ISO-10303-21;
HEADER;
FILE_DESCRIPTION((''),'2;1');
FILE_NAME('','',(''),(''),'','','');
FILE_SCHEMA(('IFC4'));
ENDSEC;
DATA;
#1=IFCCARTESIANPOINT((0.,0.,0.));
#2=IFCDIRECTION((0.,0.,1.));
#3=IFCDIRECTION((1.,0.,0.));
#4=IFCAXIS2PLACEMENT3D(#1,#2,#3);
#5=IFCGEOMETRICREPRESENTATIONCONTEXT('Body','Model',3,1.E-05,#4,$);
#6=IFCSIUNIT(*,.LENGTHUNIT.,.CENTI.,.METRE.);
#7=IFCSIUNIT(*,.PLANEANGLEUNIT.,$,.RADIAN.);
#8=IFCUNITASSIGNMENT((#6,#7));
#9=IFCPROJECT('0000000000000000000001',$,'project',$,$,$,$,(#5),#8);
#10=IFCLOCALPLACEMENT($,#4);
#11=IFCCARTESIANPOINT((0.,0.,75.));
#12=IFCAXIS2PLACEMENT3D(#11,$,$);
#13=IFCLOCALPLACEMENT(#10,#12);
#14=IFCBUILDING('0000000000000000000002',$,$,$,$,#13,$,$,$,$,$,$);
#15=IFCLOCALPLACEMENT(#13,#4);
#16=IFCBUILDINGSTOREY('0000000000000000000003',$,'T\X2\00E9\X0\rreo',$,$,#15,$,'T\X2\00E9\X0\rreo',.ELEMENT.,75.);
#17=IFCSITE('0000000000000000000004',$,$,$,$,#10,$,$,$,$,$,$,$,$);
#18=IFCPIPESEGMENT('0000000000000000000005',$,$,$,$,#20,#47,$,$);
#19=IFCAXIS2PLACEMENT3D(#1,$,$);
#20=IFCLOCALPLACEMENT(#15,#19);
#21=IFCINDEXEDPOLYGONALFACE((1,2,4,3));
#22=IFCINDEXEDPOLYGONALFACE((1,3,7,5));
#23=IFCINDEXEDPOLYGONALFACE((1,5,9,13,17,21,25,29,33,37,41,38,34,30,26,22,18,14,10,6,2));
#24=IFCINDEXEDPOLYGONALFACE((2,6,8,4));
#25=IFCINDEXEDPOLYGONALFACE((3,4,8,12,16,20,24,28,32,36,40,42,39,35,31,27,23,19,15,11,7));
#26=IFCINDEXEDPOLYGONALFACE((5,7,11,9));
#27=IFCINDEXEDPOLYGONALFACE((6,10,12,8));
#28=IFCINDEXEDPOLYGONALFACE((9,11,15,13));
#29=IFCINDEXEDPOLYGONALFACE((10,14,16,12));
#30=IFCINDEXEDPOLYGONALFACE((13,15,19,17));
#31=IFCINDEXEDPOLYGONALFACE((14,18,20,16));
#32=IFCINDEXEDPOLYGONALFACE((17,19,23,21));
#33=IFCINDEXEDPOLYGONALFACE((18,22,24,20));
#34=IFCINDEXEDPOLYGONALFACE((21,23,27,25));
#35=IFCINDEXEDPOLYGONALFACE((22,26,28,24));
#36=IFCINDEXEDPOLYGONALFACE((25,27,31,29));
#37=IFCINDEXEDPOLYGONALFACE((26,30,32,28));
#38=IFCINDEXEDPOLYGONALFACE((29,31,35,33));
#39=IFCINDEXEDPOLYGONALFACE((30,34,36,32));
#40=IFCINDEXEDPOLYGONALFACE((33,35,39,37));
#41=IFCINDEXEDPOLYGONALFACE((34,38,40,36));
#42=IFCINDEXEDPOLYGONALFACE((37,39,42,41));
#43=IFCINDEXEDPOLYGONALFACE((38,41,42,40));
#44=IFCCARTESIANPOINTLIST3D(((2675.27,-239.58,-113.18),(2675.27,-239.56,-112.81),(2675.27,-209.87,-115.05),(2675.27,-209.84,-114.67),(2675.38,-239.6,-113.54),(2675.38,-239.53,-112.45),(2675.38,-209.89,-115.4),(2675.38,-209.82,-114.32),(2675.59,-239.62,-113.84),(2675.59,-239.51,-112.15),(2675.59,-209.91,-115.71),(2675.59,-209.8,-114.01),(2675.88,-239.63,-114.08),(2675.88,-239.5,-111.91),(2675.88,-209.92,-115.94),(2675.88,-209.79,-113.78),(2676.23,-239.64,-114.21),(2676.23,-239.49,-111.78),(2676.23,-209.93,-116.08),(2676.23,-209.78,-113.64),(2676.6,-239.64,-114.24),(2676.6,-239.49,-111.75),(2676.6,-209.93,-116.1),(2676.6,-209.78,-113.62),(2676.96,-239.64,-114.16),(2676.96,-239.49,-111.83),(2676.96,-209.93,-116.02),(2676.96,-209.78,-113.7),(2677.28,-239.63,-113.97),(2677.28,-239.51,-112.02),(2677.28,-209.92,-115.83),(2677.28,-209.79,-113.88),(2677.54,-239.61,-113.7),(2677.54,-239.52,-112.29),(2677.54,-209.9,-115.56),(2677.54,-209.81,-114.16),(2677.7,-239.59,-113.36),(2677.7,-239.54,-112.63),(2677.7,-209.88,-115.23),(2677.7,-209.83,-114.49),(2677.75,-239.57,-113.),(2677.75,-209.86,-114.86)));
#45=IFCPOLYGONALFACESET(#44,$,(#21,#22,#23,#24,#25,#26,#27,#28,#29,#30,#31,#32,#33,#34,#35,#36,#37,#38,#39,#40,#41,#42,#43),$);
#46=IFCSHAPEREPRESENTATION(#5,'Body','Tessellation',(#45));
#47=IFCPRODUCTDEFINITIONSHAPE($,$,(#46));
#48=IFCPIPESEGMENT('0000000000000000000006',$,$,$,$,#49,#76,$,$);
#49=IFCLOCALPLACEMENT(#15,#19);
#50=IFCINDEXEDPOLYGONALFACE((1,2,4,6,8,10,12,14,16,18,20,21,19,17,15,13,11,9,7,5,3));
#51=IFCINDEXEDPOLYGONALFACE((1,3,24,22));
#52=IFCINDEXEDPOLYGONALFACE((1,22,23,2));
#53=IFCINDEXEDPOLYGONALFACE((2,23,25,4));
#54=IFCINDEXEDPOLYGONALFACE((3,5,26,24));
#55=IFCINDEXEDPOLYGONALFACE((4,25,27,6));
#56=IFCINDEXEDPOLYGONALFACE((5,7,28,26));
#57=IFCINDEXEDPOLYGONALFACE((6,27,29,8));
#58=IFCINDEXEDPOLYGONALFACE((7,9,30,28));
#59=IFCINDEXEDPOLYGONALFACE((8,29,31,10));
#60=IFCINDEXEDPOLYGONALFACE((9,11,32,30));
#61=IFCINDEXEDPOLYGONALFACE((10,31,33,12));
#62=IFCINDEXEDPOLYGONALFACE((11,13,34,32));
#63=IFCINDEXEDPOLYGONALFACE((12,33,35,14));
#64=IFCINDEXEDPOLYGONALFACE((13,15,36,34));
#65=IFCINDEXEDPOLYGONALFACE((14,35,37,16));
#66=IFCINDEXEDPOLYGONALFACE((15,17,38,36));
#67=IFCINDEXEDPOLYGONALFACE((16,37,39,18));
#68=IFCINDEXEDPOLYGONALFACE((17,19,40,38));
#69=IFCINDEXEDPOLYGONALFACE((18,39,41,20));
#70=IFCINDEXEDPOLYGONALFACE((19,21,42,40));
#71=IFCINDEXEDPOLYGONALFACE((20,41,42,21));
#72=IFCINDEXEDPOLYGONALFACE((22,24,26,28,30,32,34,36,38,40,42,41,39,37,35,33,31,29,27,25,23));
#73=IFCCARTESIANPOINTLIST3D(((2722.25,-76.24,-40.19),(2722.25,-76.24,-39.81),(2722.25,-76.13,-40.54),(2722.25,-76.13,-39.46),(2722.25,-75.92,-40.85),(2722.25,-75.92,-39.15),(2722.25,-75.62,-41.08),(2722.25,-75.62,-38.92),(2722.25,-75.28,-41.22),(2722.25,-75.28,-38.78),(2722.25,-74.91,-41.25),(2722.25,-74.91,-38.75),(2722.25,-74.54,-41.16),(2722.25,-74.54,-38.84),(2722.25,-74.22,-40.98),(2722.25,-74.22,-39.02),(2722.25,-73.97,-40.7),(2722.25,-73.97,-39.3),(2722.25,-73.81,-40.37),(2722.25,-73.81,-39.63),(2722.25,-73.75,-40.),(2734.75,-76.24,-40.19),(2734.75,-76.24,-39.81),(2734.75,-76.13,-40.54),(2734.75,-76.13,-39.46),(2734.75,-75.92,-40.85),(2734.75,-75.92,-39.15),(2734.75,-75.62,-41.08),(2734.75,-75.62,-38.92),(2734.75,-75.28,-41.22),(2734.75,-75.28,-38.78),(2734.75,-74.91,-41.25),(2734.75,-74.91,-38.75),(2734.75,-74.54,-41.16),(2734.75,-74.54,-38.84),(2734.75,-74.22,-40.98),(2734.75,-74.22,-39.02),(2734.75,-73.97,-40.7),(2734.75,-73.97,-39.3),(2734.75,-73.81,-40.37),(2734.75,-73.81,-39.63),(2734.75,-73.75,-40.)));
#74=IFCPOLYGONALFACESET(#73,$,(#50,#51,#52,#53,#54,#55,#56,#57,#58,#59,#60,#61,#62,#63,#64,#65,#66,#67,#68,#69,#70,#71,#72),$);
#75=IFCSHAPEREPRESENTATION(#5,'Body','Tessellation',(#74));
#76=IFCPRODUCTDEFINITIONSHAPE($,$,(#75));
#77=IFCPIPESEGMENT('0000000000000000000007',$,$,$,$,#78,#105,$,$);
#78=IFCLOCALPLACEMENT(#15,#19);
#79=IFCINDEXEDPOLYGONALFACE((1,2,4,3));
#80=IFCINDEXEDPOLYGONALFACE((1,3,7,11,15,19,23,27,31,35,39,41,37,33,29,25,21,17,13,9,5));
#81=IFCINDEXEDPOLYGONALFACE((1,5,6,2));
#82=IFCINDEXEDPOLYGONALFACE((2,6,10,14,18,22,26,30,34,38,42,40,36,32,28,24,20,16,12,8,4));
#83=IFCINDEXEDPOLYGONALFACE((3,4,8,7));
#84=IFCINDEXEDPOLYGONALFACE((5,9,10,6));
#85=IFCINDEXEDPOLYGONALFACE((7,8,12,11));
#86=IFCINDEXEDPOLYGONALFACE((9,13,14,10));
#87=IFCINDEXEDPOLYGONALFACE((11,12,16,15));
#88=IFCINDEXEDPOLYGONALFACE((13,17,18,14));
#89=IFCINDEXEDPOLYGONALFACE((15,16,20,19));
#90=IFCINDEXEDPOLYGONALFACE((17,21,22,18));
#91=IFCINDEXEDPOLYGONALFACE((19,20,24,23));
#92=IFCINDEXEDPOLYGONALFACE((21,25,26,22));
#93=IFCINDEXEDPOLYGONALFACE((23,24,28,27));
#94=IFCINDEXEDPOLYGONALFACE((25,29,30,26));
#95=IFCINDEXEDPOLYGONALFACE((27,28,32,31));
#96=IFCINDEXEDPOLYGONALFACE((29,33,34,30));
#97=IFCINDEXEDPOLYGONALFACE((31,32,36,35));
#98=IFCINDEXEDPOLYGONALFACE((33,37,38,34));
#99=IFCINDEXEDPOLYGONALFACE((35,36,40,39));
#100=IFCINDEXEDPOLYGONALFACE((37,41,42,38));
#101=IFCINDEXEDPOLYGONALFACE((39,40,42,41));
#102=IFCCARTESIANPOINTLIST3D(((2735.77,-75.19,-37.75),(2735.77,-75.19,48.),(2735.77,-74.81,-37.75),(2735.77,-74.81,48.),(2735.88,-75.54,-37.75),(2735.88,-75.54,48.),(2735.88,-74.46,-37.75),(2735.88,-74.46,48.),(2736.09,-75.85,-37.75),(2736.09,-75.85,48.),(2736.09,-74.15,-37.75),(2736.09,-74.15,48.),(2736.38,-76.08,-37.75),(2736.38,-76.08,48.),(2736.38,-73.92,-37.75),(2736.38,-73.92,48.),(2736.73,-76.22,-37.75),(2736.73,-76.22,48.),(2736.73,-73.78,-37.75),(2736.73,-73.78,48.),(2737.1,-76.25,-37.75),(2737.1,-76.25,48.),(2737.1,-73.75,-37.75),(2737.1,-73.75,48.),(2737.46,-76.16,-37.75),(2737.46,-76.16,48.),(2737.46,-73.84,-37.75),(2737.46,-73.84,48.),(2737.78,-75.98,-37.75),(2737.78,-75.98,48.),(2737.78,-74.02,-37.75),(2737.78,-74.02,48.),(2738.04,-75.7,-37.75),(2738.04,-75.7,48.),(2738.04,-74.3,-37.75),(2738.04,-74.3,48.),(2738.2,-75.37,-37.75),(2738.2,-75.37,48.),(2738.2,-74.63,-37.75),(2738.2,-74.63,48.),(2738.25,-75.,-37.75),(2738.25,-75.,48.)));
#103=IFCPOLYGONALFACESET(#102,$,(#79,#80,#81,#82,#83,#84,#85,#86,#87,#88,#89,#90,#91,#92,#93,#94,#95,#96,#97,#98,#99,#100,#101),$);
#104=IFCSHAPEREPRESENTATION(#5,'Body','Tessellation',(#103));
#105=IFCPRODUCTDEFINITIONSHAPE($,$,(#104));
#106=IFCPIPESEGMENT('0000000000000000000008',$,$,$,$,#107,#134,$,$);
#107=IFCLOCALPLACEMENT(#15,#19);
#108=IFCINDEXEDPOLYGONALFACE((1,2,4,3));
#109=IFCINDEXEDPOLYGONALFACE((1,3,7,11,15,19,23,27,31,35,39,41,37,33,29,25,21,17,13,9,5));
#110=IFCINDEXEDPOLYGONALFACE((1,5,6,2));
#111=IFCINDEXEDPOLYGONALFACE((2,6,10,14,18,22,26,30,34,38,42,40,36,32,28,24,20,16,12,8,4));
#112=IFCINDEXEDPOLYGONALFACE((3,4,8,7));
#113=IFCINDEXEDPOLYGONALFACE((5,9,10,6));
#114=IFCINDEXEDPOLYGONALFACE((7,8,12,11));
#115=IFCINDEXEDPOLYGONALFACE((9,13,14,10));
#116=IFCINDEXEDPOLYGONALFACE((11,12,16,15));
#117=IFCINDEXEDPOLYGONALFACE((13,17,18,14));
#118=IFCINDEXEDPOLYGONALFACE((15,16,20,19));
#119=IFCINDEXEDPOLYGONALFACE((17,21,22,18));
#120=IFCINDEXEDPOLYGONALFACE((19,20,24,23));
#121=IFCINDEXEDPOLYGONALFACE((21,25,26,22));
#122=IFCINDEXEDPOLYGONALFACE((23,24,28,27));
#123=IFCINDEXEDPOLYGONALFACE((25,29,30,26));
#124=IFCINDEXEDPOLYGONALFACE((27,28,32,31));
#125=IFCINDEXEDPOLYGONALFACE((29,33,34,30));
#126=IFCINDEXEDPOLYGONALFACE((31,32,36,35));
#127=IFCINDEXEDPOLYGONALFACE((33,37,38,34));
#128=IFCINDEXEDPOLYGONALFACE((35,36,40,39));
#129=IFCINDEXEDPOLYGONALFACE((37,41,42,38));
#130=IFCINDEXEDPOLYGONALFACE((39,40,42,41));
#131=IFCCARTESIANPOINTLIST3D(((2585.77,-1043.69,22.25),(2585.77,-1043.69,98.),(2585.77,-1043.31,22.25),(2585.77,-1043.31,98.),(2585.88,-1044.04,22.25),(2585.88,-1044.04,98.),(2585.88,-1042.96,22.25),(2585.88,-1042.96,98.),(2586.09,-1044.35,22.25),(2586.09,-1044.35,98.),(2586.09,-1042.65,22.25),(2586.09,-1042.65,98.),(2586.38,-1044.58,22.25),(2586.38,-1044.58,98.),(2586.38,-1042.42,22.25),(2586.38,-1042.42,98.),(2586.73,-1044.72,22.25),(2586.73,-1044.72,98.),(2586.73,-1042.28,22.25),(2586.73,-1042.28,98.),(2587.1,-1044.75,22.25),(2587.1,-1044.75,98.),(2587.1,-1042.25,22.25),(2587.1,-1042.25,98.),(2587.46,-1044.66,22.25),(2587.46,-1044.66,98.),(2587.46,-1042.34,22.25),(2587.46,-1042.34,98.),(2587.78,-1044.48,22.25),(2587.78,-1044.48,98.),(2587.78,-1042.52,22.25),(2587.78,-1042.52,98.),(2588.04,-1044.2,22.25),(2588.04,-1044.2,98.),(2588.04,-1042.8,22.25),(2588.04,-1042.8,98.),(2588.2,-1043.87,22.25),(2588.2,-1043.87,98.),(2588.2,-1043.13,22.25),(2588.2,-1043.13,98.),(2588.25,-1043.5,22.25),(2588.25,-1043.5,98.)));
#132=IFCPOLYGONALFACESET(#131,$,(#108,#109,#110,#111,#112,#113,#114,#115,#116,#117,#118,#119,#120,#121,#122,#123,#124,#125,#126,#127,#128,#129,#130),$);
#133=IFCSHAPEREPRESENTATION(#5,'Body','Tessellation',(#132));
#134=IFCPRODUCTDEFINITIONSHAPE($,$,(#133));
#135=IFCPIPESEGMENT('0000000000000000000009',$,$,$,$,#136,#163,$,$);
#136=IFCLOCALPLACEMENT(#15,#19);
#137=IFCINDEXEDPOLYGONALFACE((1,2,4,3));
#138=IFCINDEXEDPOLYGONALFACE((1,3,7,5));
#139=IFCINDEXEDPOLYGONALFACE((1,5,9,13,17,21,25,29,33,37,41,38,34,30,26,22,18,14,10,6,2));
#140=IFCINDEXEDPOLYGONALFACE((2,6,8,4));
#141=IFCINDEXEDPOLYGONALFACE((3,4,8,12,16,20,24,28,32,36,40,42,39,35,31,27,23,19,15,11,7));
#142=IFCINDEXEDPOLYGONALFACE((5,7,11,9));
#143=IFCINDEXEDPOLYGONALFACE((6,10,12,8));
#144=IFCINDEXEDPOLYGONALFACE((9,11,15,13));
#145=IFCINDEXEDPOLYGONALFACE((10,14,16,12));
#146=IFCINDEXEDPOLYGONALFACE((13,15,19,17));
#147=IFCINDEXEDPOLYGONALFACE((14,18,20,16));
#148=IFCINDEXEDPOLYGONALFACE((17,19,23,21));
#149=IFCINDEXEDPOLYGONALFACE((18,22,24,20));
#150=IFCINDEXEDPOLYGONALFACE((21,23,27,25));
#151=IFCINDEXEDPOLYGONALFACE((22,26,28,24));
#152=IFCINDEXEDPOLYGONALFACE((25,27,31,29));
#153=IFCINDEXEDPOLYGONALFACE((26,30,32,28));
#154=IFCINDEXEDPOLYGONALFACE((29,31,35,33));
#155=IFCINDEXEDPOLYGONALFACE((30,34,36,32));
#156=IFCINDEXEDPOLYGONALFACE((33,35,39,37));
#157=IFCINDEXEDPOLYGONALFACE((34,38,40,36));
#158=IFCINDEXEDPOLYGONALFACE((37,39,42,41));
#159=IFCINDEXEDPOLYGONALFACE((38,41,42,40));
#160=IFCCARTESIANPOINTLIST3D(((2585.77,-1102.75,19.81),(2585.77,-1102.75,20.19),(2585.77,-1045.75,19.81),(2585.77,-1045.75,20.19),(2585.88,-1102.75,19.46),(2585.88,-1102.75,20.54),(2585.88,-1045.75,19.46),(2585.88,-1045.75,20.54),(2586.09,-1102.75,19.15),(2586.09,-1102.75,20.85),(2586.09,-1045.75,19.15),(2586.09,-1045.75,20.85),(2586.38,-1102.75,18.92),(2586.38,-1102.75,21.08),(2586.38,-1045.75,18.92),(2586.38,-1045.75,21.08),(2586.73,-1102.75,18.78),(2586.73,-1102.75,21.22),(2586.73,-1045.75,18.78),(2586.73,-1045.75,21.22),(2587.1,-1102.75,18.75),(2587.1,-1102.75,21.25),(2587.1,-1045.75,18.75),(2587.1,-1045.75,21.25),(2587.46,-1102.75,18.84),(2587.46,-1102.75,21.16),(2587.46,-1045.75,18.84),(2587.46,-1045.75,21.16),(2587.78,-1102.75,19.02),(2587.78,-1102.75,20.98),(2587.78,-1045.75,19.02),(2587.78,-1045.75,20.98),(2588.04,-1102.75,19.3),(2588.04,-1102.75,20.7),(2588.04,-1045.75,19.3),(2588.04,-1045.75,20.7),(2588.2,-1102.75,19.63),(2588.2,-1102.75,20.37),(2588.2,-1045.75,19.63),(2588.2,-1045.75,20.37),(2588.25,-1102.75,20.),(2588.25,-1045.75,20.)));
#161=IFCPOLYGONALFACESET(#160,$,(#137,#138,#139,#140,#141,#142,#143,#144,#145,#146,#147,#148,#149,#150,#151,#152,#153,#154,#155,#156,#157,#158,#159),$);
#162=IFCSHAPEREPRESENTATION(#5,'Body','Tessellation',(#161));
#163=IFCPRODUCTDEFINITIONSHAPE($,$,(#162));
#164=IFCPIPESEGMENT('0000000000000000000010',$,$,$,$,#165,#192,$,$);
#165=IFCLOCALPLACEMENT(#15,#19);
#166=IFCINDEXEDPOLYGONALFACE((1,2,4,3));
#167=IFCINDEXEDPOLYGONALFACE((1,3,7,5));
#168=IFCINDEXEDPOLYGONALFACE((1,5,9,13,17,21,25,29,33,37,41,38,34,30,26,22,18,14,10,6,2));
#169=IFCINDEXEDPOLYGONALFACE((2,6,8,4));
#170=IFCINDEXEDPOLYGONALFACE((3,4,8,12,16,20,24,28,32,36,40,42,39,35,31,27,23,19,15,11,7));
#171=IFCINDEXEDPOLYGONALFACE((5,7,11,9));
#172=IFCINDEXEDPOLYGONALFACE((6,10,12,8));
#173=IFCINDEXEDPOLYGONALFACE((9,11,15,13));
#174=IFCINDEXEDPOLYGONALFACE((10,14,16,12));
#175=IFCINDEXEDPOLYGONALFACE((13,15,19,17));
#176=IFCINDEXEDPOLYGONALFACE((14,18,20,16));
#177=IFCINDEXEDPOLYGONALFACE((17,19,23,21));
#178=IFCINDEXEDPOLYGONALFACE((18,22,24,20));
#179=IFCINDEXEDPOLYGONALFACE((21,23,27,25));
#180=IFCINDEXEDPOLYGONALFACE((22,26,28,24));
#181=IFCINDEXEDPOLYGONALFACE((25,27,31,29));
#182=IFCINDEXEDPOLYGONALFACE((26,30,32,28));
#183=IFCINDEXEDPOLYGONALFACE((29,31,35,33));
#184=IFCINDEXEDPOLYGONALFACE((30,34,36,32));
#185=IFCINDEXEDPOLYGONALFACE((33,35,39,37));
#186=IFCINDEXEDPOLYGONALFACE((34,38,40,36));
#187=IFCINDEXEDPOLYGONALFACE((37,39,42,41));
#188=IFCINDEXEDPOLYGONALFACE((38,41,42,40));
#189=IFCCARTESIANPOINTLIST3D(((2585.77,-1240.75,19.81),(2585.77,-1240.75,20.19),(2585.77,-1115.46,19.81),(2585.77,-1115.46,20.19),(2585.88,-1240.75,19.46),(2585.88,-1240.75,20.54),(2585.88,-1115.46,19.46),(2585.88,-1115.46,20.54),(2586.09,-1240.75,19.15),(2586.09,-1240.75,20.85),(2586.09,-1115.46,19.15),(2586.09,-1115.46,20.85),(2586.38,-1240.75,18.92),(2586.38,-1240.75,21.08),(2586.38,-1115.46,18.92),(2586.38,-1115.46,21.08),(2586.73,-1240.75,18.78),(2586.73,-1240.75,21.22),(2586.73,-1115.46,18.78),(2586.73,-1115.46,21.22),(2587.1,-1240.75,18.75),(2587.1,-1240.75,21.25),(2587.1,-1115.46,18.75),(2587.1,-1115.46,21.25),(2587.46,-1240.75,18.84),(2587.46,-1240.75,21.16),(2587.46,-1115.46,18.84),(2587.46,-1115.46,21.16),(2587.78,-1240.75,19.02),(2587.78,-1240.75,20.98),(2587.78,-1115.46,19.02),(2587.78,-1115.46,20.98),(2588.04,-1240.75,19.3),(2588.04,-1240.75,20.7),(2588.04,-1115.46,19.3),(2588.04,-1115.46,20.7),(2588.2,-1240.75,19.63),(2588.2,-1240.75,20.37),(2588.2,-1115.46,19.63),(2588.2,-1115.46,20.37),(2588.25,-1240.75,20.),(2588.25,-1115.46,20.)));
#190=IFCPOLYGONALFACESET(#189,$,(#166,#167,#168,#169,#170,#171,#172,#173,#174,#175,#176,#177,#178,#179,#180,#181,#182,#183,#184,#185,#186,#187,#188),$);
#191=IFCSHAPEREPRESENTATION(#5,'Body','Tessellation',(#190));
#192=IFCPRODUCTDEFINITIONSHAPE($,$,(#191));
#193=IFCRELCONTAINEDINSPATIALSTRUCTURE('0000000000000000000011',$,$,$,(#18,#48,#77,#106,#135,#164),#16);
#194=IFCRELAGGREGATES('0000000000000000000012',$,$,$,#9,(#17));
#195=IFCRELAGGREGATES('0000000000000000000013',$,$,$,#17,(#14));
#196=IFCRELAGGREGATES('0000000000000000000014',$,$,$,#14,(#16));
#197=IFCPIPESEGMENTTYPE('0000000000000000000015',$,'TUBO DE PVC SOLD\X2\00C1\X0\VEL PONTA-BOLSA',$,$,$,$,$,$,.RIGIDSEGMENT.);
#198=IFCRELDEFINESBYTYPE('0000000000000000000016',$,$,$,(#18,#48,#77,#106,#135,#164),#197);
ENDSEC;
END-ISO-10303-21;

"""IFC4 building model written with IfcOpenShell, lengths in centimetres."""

from ifc_helpers import new_model, si_unit, frame, origin_with_axes, origin_2d_with_axis, place, context, project, spatial, circle, extrude, type_object, element, save


model = new_model("IFC4")

# Units and contexts
model_context = context("Model", 3, precision=1e-05, world=origin_with_axes(), identifier="Body")
ifc_project = project(units=[si_unit("LENGTHUNIT", "METRE", prefix="CENTI"), si_unit("PLANEANGLEUNIT", "RADIAN")], contexts=[model_context])

# Site, building, storey
site_placement = place(None, origin_with_axes())
site = spatial("IfcSite", under=ifc_project, at=site_placement)
building_placement = place(site_placement, frame((0.0, 0.0, 75.0)))
building = spatial("IfcBuilding", under=site, at=building_placement)
storey_placement = place(building_placement, origin_with_axes())
storey = spatial("IfcBuildingStorey", under=building, at=storey_placement, Name="Térreo", LongName="Térreo", CompositionType="ELEMENT", Elevation=75.0)

# Pipe segments
pipe_segment_type_1 = type_object("IfcPipeSegmentType", Name="TUBO DE PVC SOLDÁVEL PONTA-BOLSA", PredefinedType="RIGIDSEGMENT")
pipe_segment_1_placement = place(storey_placement, frame((2676.5, -224.71, -111.75), z_axis=(0.0, 0.0, 1.0), x_axis=(1.0, 0.0, 0.0)))
element("IfcPipeSegment", 1, at=pipe_segment_1_placement, inside=storey, type_object=pipe_segment_type_1, context=model_context, shape_type="SolidModel", body=[
    extrude(circle(Radius=1.25, at=origin_2d_with_axis()), frame((0.0, -14.86, -1.25), z_axis=(0.0, 0.998038, -0.062612), x_axis=(1.0, 0.0, 0.0)), (0.0, 0.0, 1.0), 29.77),
])
pipe_segment_2_placement = place(storey_placement, frame((2728.5, -75.0, -38.75), z_axis=(0.0, 0.0, 1.0), x_axis=(1.0, 0.0, 0.0)))
element("IfcPipeSegment", 2, at=pipe_segment_2_placement, inside=storey, type_object=pipe_segment_type_1, context=model_context, shape_type="SolidModel", body=[
    extrude(circle(Radius=1.25, at=origin_2d_with_axis()), frame((-6.25, 0.0, -1.25), z_axis=(1.0, 0.0, 0.0), x_axis=(0.0, 1.0, 0.0)), (0.0, 0.0, 1.0), 12.5),
])
pipe_segment_3_placement = place(storey_placement, frame((2737.0, -75.0, 48.0), z_axis=(0.0, 0.0, 1.0), x_axis=(1.0, 0.0, 0.0)))
element("IfcPipeSegment", 3, at=pipe_segment_3_placement, inside=storey, type_object=pipe_segment_type_1, context=model_context, shape_type="SolidModel", body=[
    extrude(circle(Radius=1.25, at=origin_2d_with_axis()), frame((0.0, 0.0, -85.75), z_axis=(0.0, 0.0, 1.0), x_axis=(1.0, 0.0, 0.0)), (0.0, 0.0, 1.0), 85.75),
])
pipe_segment_4_placement = place(storey_placement, frame((2587.0, -1043.5, 98.0), z_axis=(0.0, 0.0, 1.0), x_axis=(1.0, 0.0, 0.0)))
element("IfcPipeSegment", 4, at=pipe_segment_4_placement, inside=storey, type_object=pipe_segment_type_1, context=model_context, shape_type="SolidModel", body=[
    extrude(circle(Radius=1.25, at=origin_2d_with_axis()), frame((0.0, 0.0, -75.75), z_axis=(0.0, 0.0, 1.0), x_axis=(1.0, 0.0, 0.0)), (0.0, 0.0, 1.0), 75.75),
])
pipe_segment_5_placement = place(storey_placement, frame((2587.0, -1074.25, 21.25), z_axis=(0.0, 0.0, 1.0), x_axis=(1.0, 0.0, 0.0)))
element("IfcPipeSegment", 5, at=pipe_segment_5_placement, inside=storey, type_object=pipe_segment_type_1, context=model_context, shape_type="SolidModel", body=[
    extrude(circle(Radius=1.25, at=origin_2d_with_axis()), frame((0.0, -28.5, -1.25), z_axis=(0.0, 1.0, 0.0), x_axis=(1.0, 0.0, 0.0)), (0.0, 0.0, 1.0), 57.0),
])
pipe_segment_6_placement = place(storey_placement, frame((2587.0, -1178.1, 21.25), z_axis=(0.0, 0.0, 1.0), x_axis=(1.0, 0.0, 0.0)))
element("IfcPipeSegment", 6, at=pipe_segment_6_placement, inside=storey, type_object=pipe_segment_type_1, context=model_context, shape_type="SolidModel", body=[
    extrude(circle(Radius=1.25, at=origin_2d_with_axis()), frame((0.0, 62.65, -1.25), z_axis=(0.0, -1.0, 0.0), x_axis=(1.0, 0.0, 0.0)), (0.0, 0.0, 1.0), 125.29),
])

save(model, "model.ifc")
